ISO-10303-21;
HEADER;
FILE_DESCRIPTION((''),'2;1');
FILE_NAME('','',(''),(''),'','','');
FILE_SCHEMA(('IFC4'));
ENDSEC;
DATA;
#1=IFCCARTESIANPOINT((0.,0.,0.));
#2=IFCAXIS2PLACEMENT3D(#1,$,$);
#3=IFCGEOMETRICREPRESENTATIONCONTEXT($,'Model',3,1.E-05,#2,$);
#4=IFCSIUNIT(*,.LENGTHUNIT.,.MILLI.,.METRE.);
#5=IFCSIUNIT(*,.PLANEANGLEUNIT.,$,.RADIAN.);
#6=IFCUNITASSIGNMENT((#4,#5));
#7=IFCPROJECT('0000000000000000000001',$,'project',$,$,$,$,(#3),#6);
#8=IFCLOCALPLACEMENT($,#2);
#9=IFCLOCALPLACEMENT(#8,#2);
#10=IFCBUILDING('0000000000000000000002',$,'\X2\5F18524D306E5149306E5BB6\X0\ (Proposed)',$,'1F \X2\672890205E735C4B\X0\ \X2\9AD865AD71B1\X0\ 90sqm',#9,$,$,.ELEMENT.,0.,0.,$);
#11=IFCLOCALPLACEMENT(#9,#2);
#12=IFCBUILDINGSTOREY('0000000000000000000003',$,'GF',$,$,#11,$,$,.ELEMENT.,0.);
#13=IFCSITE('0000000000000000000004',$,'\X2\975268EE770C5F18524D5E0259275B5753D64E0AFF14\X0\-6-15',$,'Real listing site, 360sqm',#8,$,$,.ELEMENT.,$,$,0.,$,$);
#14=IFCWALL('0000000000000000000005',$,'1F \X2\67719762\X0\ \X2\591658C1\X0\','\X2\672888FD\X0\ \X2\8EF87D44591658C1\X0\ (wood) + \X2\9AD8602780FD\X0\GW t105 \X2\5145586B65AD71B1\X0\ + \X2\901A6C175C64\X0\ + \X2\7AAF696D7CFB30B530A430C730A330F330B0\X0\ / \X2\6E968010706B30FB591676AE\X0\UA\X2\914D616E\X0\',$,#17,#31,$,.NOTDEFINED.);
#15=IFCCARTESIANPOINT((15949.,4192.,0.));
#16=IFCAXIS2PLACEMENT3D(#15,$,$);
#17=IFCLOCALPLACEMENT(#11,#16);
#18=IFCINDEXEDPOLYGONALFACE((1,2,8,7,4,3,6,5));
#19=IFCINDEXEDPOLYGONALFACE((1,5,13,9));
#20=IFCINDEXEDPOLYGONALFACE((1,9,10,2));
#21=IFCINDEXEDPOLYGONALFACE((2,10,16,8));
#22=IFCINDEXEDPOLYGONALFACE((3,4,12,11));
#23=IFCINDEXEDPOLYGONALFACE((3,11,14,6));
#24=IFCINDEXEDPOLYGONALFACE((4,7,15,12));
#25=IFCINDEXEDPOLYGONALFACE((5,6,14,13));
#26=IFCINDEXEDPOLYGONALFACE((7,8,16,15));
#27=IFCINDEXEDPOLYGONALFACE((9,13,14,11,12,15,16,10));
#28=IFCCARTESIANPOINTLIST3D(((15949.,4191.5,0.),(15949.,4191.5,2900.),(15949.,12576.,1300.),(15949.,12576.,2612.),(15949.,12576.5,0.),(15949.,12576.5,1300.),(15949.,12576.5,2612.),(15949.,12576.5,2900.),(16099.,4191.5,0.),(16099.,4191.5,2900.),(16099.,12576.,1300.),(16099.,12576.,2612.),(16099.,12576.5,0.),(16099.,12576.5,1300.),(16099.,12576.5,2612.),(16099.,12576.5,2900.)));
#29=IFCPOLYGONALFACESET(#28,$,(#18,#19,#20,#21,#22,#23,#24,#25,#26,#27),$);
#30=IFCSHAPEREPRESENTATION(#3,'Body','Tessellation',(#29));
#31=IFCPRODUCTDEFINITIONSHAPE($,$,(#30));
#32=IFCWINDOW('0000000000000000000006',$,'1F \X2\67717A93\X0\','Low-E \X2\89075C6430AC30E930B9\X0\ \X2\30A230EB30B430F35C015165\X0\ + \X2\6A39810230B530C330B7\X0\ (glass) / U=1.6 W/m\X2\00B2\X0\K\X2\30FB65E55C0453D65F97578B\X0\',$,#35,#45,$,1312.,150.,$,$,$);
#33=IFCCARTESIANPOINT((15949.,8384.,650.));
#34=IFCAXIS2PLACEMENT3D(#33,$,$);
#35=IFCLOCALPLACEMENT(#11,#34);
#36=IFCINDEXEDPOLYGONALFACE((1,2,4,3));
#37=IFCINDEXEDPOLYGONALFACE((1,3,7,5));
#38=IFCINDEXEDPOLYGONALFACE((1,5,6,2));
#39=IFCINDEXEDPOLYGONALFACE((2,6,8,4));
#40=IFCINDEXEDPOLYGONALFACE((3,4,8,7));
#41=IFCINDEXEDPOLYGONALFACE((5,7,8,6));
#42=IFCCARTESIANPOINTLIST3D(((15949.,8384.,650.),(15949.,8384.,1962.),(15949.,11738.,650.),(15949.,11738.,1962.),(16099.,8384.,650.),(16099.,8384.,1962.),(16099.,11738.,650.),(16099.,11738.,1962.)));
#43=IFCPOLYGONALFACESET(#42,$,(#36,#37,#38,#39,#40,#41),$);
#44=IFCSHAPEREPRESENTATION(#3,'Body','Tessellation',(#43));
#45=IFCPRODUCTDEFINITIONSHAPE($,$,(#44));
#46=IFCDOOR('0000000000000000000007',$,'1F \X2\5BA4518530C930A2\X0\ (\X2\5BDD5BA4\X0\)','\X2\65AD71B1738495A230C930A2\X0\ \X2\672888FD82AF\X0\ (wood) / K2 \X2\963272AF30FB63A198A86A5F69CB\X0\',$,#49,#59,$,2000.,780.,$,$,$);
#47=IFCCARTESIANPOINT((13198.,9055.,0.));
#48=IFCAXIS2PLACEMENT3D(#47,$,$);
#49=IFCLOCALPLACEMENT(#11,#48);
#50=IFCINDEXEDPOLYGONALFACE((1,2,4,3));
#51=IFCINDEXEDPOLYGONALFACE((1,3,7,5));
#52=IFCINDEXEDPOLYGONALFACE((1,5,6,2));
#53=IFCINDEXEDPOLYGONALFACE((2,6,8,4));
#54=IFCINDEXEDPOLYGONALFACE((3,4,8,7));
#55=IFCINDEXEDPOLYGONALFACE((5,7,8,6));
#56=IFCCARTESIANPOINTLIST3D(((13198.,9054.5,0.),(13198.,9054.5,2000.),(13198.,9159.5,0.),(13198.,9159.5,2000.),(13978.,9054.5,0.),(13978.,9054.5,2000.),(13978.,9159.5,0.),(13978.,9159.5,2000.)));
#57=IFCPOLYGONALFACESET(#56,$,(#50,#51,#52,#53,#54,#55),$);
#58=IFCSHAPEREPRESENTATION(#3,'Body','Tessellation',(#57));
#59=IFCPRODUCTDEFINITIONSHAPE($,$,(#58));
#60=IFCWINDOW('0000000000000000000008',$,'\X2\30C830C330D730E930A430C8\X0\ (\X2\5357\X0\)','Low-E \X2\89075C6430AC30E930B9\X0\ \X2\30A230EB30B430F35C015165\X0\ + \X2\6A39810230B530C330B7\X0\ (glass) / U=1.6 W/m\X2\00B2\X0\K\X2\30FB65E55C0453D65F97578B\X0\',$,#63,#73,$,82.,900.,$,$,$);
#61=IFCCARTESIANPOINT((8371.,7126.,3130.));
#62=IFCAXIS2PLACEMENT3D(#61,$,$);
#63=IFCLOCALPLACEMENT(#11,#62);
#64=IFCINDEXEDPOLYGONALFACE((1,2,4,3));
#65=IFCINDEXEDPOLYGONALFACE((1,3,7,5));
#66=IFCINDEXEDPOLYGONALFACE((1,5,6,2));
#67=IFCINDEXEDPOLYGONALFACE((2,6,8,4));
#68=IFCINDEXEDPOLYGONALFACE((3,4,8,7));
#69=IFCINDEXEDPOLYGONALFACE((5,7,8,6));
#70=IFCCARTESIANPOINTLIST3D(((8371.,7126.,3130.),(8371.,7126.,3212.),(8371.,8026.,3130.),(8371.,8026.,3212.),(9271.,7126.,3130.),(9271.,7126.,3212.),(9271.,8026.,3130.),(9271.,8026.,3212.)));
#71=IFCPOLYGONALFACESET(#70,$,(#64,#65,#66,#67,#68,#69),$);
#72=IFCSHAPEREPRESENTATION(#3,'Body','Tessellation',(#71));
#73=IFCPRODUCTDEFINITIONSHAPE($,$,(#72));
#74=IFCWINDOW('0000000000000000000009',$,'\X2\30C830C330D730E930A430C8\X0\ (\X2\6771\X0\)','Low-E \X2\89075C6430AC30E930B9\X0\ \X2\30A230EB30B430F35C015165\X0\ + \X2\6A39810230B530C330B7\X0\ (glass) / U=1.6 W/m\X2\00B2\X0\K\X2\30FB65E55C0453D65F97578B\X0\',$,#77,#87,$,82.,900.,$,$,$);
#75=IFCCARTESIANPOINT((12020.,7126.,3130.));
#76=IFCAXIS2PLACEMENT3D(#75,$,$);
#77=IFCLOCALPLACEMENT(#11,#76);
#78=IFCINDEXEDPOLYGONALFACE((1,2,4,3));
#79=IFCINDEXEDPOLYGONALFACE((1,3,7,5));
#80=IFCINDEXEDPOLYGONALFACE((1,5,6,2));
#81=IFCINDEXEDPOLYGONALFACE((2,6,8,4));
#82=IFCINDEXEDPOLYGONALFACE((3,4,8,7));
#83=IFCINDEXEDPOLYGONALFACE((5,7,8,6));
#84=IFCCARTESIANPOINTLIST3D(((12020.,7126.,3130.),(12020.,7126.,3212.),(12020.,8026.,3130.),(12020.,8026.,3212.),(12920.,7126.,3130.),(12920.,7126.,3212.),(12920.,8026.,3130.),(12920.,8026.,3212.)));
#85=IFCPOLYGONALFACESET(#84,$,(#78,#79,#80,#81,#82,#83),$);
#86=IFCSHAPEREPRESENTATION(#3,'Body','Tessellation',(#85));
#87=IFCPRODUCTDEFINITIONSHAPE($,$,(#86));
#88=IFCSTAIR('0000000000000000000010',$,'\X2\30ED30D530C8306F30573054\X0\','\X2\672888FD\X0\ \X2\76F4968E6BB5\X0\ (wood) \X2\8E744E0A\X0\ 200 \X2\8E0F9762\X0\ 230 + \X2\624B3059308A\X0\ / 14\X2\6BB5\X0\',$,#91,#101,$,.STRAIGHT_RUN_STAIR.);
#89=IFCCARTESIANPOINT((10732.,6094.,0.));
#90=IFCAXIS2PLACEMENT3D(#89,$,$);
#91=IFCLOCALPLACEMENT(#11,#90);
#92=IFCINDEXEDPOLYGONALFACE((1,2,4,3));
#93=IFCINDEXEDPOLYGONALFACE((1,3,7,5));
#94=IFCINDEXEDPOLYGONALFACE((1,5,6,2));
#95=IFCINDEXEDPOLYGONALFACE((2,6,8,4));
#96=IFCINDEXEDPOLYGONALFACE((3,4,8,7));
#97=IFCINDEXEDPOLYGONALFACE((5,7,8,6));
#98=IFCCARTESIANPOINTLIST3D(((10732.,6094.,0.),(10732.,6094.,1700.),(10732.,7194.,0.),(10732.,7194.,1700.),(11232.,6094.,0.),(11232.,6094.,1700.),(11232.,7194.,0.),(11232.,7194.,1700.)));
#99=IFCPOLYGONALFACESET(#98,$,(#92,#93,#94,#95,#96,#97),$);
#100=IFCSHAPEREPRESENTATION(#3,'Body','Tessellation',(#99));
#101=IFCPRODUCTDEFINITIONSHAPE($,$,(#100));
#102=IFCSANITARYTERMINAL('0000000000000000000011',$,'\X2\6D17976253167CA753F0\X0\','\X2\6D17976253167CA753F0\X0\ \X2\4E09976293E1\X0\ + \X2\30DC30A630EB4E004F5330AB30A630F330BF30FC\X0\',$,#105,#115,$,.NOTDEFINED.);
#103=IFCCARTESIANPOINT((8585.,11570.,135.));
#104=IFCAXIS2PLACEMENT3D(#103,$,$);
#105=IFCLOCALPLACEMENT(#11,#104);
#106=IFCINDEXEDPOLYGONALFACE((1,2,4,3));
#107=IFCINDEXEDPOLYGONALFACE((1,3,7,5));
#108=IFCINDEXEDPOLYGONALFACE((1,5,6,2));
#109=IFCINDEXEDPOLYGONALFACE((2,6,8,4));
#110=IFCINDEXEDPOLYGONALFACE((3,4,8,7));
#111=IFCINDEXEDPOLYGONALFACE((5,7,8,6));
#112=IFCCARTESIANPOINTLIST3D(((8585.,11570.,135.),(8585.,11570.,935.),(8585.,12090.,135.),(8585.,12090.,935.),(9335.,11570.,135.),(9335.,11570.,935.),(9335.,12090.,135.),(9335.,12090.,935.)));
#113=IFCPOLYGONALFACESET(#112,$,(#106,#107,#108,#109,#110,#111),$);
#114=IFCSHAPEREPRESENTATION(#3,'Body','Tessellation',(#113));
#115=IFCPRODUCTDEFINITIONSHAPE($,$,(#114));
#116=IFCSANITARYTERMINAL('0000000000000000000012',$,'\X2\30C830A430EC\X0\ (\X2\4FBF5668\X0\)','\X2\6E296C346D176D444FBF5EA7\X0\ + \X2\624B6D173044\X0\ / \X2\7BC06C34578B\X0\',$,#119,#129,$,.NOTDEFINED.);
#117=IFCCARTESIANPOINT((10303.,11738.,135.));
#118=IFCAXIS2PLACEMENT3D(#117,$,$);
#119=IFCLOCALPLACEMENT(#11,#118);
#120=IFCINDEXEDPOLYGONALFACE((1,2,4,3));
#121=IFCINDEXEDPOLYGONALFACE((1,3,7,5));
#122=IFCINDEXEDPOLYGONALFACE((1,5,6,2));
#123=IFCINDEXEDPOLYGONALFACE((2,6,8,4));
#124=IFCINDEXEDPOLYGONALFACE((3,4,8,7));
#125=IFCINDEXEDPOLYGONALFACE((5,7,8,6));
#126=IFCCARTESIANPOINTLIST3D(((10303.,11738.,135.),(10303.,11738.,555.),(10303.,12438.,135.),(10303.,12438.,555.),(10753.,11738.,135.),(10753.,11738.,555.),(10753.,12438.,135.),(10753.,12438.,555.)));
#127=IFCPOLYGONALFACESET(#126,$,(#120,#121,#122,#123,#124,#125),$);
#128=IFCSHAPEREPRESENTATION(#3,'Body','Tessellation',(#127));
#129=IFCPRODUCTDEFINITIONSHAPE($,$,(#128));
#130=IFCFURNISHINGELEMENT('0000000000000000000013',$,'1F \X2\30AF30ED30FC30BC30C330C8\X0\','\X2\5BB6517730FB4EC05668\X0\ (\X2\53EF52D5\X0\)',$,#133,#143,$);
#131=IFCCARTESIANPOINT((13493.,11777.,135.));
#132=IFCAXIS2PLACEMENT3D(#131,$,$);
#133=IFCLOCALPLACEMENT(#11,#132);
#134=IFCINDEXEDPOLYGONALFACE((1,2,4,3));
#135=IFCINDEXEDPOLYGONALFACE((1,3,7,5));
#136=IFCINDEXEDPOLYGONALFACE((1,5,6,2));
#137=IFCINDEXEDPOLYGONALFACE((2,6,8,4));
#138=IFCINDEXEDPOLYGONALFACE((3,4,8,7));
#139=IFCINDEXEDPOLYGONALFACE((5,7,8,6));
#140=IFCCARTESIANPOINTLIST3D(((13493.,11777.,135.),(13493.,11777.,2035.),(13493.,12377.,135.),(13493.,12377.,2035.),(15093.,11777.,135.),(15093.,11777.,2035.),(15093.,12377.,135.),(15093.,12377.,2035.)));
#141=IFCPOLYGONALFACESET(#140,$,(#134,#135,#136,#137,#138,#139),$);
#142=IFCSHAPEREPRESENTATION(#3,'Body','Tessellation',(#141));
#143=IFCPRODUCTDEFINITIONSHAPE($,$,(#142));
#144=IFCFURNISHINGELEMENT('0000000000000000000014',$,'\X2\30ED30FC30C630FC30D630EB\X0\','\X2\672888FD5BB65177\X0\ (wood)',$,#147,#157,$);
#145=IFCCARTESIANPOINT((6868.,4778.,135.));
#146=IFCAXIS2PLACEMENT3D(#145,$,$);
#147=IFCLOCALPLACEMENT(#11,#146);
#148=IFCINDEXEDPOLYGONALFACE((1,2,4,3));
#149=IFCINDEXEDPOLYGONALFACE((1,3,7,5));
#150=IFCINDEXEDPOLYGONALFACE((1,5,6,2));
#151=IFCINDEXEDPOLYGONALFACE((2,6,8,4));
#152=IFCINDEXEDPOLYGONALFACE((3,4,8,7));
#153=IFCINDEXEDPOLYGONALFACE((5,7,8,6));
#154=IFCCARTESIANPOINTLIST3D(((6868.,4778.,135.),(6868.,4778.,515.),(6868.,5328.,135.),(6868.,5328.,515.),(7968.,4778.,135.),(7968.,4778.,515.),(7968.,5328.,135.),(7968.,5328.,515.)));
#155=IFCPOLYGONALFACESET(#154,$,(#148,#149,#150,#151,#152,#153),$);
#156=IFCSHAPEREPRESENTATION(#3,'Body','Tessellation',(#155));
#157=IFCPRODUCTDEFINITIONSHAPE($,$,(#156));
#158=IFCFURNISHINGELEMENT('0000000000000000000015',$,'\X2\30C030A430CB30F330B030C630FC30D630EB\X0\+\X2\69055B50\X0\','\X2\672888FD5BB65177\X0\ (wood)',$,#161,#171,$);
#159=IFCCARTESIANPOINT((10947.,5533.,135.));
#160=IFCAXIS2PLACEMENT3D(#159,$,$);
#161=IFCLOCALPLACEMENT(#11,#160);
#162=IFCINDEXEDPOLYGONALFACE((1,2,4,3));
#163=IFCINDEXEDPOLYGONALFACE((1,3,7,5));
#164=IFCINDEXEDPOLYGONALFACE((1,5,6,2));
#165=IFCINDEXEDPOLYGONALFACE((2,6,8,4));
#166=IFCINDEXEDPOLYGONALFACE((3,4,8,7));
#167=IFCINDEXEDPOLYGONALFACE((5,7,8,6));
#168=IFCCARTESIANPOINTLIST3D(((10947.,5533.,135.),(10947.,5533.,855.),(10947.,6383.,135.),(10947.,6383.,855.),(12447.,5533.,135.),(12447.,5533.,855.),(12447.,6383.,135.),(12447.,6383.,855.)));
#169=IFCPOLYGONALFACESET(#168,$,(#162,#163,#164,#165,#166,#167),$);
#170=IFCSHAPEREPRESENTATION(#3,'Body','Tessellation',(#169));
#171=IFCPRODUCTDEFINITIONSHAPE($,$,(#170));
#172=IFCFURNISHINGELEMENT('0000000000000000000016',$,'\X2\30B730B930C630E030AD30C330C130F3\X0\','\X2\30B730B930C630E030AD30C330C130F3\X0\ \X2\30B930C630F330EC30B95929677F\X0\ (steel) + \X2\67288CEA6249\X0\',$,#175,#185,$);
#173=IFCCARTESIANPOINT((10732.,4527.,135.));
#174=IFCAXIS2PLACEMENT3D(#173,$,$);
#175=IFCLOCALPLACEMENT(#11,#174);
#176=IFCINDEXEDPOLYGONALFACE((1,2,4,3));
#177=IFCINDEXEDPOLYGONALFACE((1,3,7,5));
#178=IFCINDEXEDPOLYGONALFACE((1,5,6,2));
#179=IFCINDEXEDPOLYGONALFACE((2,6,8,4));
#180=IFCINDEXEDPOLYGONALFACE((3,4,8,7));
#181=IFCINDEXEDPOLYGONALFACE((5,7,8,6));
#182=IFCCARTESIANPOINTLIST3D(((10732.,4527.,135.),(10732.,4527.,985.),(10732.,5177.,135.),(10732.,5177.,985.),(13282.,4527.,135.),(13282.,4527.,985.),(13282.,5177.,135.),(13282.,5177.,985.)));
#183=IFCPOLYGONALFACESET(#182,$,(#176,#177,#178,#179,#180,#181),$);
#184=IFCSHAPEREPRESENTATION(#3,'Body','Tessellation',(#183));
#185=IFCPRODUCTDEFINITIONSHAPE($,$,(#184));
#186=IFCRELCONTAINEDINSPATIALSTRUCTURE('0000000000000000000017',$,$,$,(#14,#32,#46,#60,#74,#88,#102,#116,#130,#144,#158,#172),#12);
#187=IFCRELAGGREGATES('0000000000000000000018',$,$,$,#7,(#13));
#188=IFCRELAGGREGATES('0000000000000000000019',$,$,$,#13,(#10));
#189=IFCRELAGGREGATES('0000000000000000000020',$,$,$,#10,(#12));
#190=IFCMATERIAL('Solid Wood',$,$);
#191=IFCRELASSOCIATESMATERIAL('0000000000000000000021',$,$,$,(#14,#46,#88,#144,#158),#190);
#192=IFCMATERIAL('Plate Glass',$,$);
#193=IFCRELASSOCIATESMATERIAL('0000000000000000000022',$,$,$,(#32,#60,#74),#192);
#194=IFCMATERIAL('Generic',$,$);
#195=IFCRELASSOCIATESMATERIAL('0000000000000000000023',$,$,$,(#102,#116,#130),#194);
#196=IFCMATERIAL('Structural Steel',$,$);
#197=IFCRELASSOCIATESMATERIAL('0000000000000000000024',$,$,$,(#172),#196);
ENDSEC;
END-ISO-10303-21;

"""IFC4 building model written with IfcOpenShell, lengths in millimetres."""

from ifc_helpers import new_model, si_unit, frame, frame_2d, origin, place, context, project, spatial, rectangle, extrude, material, element, fill, save


model = new_model("IFC4")

# Units and contexts
model_context = context("Model", 3, precision=1e-05, world=origin())
ifc_project = project(units=[si_unit("LENGTHUNIT", "METRE", prefix="MILLI"), si_unit("PLANEANGLEUNIT", "RADIAN")], contexts=[model_context])

# Site, building, storey
site_placement = place(None, origin())
site = spatial("IfcSite", under=ifc_project, at=site_placement, Name="青森県弘前市大字取上４-6-15", ObjectType="Real listing site, 360sqm", CompositionType="ELEMENT", RefElevation=0.0)
building_placement = place(site_placement, origin())
building = spatial("IfcBuilding", under=site, at=building_placement, Name="弘前の光の家 (Proposed)", ObjectType="1F 木造平屋 高断熱 90sqm", CompositionType="ELEMENT", ElevationOfRefHeight=0.0, ElevationOfTerrain=0.0)
storey_placement = place(building_placement, origin())
storey = spatial("IfcBuildingStorey", under=building, at=storey_placement, Name="GF", CompositionType="ELEMENT", Elevation=0.0)

# Wall, opening, window
ifc_material_1 = material(Name="Solid Wood")
wall_1_placement = place(storey_placement, frame((15949.0, 4192.0, 0.0)))
wall_1 = element("IfcWall", 1, at=wall_1_placement, inside=storey, material=ifc_material_1, Name="1F 東面 外壁", Description="木製 軸組外壁 (wood) + 高性能GW t105 充填断熱 + 通気層 + 窯業系サイディング / 準耐火・外皮UA配慮", PredefinedType="NOTDEFINED", context=model_context, shape_type="SweptSolid", body=[
    extrude(rectangle(XDim=150.0, YDim=8385.0, at=frame_2d((75.0, 4192.0))), frame((15949.0, 4192.0, 0.0)), (0.0, 0.0, 1.0), 2900.0),
])
opening_placement = place(storey_placement, frame((15949.0, 8384.0, 650.0)))
opening = element("IfcOpeningElement", 2, at=opening_placement, cuts=wall_1, PredefinedType="NOTDEFINED", context=model_context, shape_type="SweptSolid", body=[
    extrude(rectangle(XDim=150.0, YDim=3354.0, at=frame_2d((75.0, 1677.0))), frame((15949.0, 8384.0, 650.0)), (0.0, 0.0, 1.0), 1312.0),
])
ifc_material_2 = material(Name="Plate Glass")
window_1_placement = place(storey_placement, frame((15949.0, 8384.0, 650.0)))
window_1 = element("IfcWindow", 3, at=window_1_placement, inside=storey, material=ifc_material_2, Name="1F 東窓", Description="Low-E 複層ガラス アルゴン封入 + 樹脂サッシ (glass) / U=1.6 W/m²K・日射取得型", OverallHeight=1312.0, OverallWidth=150.0, context=model_context, shape_type="SweptSolid", body=[
    extrude(rectangle(XDim=150.0, YDim=3354.0, at=frame_2d((75.0, 1677.0))), frame((15949.0, 8384.0, 650.0)), (0.0, 0.0, 1.0), 1312.0),
])
fill(opening, window_1)

# Door
door_placement = place(storey_placement, frame((13198.0, 9055.0, 0.0)))
element("IfcDoor", 4, at=door_placement, inside=storey, material=ifc_material_1, Name="1F 室内ドア (寝室)", Description="断熱玄関ドア 木製芯 (wood) / K2 防犯・採風機構", OverallHeight=2000.0, OverallWidth=780.0, context=model_context, shape_type="SweptSolid", body=[
    extrude(rectangle(XDim=780.0, YDim=105.0, at=frame_2d((390.0, 52.0))), frame((13198.0, 9055.0, 0.0)), (0.0, 0.0, 1.0), 2000.0),
])

# Windows
window_2_placement = place(storey_placement, frame((8371.0, 7126.0, 3130.0)))
element("IfcWindow", 5, at=window_2_placement, inside=storey, material=ifc_material_2, Name="トップライト (南)", Description="Low-E 複層ガラス アルゴン封入 + 樹脂サッシ (glass) / U=1.6 W/m²K・日射取得型", OverallHeight=82.0, OverallWidth=900.0, context=model_context, shape_type="SweptSolid", body=[
    extrude(rectangle(XDim=900.0, YDim=900.0, at=frame_2d((450.0, 450.0))), frame((8371.0, 7126.0, 3130.0)), (0.0, 0.0, 1.0), 82.0),
])
window_3_placement = place(storey_placement, frame((12020.0, 7126.0, 3130.0)))
element("IfcWindow", 6, at=window_3_placement, inside=storey, material=ifc_material_2, Name="トップライト (東)", Description="Low-E 複層ガラス アルゴン封入 + 樹脂サッシ (glass) / U=1.6 W/m²K・日射取得型", OverallHeight=82.0, OverallWidth=900.0, context=model_context, shape_type="SweptSolid", body=[
    extrude(rectangle(XDim=900.0, YDim=900.0, at=frame_2d((450.0, 450.0))), frame((12020.0, 7126.0, 3130.0)), (0.0, 0.0, 1.0), 82.0),
])

# Stair
stair_placement = place(storey_placement, frame((10732.0, 6094.0, 0.0)))
element("IfcStair", 7, at=stair_placement, inside=storey, material=ifc_material_1, Name="ロフトはしご", Description="木製 直階段 (wood) 蹴上 200 踏面 230 + 手すり / 14段", PredefinedType="STRAIGHT_RUN_STAIR", context=model_context, shape_type="SweptSolid", body=[
    extrude(rectangle(XDim=500.0, YDim=1100.0, at=frame_2d((250.0, 550.0))), frame((10732.0, 6094.0, 0.0)), (0.0, 0.0, 1.0), 1700.0),
])

# Sanitary terminals
ifc_material_3 = material(Name="Generic")
sanitary_terminal_1_placement = place(storey_placement, frame((8585.0, 11570.0, 135.0)))
element("IfcSanitaryTerminal", 8, at=sanitary_terminal_1_placement, inside=storey, material=ifc_material_3, Name="洗面化粧台", Description="洗面化粧台 三面鏡 + ボウル一体カウンター", PredefinedType="NOTDEFINED", context=model_context, shape_type="SweptSolid", body=[
    extrude(rectangle(XDim=750.0, YDim=520.0, at=frame_2d((375.0, 260.0))), frame((8585.0, 11570.0, 135.0)), (0.0, 0.0, 1.0), 800.0),
])
sanitary_terminal_2_placement = place(storey_placement, frame((10303.0, 11738.0, 135.0)))
element("IfcSanitaryTerminal", 9, at=sanitary_terminal_2_placement, inside=storey, material=ifc_material_3, Name="トイレ (便器)", Description="温水洗浄便座 + 手洗い / 節水型", PredefinedType="NOTDEFINED", context=model_context, shape_type="SweptSolid", body=[
    extrude(rectangle(XDim=450.0, YDim=700.0, at=frame_2d((225.0, 350.0))), frame((10303.0, 11738.0, 135.0)), (0.0, 0.0, 1.0), 420.0),
])

# Furnishing elements
furnishing_1_placement = place(storey_placement, frame((13493.0, 11777.0, 135.0)))
element("IfcFurnishingElement", 10, at=furnishing_1_placement, inside=storey, material=ifc_material_3, Name="1F クローゼット", Description="家具・什器 (可動)", context=model_context, shape_type="SweptSolid", body=[
    extrude(rectangle(XDim=1600.0, YDim=600.0, at=frame_2d((800.0, 300.0))), frame((13493.0, 11777.0, 135.0)), (0.0, 0.0, 1.0), 1900.0),
])
furnishing_2_placement = place(storey_placement, frame((6868.0, 4778.0, 135.0)))
element("IfcFurnishingElement", 11, at=furnishing_2_placement, inside=storey, material=ifc_material_1, Name="ローテーブル", Description="木製家具 (wood)", context=model_context, shape_type="SweptSolid", body=[
    extrude(rectangle(XDim=1100.0, YDim=550.0, at=frame_2d((550.0, 275.0))), frame((6868.0, 4778.0, 135.0)), (0.0, 0.0, 1.0), 380.0),
])
furnishing_3_placement = place(storey_placement, frame((10947.0, 5533.0, 135.0)))
element("IfcFurnishingElement", 12, at=furnishing_3_placement, inside=storey, material=ifc_material_1, Name="ダイニングテーブル+椅子", Description="木製家具 (wood)", context=model_context, shape_type="SweptSolid", body=[
    extrude(rectangle(XDim=1500.0, YDim=850.0, at=frame_2d((750.0, 425.0))), frame((10947.0, 5533.0, 135.0)), (0.0, 0.0, 1.0), 720.0),
])
ifc_material_4 = material(Name="Structural Steel")
furnishing_4_placement = place(storey_placement, frame((10732.0, 4527.0, 135.0)))
element("IfcFurnishingElement", 13, at=furnishing_4_placement, inside=storey, material=ifc_material_4, Name="システムキッチン", Description="システムキッチン ステンレス天板 (steel) + 木質扉", context=model_context, shape_type="SweptSolid", body=[
    extrude(rectangle(XDim=2550.0, YDim=650.0, at=frame_2d((1275.0, 325.0))), frame((10732.0, 4527.0, 135.0)), (0.0, 0.0, 1.0), 850.0),
])

save(model, "model.ifc")
